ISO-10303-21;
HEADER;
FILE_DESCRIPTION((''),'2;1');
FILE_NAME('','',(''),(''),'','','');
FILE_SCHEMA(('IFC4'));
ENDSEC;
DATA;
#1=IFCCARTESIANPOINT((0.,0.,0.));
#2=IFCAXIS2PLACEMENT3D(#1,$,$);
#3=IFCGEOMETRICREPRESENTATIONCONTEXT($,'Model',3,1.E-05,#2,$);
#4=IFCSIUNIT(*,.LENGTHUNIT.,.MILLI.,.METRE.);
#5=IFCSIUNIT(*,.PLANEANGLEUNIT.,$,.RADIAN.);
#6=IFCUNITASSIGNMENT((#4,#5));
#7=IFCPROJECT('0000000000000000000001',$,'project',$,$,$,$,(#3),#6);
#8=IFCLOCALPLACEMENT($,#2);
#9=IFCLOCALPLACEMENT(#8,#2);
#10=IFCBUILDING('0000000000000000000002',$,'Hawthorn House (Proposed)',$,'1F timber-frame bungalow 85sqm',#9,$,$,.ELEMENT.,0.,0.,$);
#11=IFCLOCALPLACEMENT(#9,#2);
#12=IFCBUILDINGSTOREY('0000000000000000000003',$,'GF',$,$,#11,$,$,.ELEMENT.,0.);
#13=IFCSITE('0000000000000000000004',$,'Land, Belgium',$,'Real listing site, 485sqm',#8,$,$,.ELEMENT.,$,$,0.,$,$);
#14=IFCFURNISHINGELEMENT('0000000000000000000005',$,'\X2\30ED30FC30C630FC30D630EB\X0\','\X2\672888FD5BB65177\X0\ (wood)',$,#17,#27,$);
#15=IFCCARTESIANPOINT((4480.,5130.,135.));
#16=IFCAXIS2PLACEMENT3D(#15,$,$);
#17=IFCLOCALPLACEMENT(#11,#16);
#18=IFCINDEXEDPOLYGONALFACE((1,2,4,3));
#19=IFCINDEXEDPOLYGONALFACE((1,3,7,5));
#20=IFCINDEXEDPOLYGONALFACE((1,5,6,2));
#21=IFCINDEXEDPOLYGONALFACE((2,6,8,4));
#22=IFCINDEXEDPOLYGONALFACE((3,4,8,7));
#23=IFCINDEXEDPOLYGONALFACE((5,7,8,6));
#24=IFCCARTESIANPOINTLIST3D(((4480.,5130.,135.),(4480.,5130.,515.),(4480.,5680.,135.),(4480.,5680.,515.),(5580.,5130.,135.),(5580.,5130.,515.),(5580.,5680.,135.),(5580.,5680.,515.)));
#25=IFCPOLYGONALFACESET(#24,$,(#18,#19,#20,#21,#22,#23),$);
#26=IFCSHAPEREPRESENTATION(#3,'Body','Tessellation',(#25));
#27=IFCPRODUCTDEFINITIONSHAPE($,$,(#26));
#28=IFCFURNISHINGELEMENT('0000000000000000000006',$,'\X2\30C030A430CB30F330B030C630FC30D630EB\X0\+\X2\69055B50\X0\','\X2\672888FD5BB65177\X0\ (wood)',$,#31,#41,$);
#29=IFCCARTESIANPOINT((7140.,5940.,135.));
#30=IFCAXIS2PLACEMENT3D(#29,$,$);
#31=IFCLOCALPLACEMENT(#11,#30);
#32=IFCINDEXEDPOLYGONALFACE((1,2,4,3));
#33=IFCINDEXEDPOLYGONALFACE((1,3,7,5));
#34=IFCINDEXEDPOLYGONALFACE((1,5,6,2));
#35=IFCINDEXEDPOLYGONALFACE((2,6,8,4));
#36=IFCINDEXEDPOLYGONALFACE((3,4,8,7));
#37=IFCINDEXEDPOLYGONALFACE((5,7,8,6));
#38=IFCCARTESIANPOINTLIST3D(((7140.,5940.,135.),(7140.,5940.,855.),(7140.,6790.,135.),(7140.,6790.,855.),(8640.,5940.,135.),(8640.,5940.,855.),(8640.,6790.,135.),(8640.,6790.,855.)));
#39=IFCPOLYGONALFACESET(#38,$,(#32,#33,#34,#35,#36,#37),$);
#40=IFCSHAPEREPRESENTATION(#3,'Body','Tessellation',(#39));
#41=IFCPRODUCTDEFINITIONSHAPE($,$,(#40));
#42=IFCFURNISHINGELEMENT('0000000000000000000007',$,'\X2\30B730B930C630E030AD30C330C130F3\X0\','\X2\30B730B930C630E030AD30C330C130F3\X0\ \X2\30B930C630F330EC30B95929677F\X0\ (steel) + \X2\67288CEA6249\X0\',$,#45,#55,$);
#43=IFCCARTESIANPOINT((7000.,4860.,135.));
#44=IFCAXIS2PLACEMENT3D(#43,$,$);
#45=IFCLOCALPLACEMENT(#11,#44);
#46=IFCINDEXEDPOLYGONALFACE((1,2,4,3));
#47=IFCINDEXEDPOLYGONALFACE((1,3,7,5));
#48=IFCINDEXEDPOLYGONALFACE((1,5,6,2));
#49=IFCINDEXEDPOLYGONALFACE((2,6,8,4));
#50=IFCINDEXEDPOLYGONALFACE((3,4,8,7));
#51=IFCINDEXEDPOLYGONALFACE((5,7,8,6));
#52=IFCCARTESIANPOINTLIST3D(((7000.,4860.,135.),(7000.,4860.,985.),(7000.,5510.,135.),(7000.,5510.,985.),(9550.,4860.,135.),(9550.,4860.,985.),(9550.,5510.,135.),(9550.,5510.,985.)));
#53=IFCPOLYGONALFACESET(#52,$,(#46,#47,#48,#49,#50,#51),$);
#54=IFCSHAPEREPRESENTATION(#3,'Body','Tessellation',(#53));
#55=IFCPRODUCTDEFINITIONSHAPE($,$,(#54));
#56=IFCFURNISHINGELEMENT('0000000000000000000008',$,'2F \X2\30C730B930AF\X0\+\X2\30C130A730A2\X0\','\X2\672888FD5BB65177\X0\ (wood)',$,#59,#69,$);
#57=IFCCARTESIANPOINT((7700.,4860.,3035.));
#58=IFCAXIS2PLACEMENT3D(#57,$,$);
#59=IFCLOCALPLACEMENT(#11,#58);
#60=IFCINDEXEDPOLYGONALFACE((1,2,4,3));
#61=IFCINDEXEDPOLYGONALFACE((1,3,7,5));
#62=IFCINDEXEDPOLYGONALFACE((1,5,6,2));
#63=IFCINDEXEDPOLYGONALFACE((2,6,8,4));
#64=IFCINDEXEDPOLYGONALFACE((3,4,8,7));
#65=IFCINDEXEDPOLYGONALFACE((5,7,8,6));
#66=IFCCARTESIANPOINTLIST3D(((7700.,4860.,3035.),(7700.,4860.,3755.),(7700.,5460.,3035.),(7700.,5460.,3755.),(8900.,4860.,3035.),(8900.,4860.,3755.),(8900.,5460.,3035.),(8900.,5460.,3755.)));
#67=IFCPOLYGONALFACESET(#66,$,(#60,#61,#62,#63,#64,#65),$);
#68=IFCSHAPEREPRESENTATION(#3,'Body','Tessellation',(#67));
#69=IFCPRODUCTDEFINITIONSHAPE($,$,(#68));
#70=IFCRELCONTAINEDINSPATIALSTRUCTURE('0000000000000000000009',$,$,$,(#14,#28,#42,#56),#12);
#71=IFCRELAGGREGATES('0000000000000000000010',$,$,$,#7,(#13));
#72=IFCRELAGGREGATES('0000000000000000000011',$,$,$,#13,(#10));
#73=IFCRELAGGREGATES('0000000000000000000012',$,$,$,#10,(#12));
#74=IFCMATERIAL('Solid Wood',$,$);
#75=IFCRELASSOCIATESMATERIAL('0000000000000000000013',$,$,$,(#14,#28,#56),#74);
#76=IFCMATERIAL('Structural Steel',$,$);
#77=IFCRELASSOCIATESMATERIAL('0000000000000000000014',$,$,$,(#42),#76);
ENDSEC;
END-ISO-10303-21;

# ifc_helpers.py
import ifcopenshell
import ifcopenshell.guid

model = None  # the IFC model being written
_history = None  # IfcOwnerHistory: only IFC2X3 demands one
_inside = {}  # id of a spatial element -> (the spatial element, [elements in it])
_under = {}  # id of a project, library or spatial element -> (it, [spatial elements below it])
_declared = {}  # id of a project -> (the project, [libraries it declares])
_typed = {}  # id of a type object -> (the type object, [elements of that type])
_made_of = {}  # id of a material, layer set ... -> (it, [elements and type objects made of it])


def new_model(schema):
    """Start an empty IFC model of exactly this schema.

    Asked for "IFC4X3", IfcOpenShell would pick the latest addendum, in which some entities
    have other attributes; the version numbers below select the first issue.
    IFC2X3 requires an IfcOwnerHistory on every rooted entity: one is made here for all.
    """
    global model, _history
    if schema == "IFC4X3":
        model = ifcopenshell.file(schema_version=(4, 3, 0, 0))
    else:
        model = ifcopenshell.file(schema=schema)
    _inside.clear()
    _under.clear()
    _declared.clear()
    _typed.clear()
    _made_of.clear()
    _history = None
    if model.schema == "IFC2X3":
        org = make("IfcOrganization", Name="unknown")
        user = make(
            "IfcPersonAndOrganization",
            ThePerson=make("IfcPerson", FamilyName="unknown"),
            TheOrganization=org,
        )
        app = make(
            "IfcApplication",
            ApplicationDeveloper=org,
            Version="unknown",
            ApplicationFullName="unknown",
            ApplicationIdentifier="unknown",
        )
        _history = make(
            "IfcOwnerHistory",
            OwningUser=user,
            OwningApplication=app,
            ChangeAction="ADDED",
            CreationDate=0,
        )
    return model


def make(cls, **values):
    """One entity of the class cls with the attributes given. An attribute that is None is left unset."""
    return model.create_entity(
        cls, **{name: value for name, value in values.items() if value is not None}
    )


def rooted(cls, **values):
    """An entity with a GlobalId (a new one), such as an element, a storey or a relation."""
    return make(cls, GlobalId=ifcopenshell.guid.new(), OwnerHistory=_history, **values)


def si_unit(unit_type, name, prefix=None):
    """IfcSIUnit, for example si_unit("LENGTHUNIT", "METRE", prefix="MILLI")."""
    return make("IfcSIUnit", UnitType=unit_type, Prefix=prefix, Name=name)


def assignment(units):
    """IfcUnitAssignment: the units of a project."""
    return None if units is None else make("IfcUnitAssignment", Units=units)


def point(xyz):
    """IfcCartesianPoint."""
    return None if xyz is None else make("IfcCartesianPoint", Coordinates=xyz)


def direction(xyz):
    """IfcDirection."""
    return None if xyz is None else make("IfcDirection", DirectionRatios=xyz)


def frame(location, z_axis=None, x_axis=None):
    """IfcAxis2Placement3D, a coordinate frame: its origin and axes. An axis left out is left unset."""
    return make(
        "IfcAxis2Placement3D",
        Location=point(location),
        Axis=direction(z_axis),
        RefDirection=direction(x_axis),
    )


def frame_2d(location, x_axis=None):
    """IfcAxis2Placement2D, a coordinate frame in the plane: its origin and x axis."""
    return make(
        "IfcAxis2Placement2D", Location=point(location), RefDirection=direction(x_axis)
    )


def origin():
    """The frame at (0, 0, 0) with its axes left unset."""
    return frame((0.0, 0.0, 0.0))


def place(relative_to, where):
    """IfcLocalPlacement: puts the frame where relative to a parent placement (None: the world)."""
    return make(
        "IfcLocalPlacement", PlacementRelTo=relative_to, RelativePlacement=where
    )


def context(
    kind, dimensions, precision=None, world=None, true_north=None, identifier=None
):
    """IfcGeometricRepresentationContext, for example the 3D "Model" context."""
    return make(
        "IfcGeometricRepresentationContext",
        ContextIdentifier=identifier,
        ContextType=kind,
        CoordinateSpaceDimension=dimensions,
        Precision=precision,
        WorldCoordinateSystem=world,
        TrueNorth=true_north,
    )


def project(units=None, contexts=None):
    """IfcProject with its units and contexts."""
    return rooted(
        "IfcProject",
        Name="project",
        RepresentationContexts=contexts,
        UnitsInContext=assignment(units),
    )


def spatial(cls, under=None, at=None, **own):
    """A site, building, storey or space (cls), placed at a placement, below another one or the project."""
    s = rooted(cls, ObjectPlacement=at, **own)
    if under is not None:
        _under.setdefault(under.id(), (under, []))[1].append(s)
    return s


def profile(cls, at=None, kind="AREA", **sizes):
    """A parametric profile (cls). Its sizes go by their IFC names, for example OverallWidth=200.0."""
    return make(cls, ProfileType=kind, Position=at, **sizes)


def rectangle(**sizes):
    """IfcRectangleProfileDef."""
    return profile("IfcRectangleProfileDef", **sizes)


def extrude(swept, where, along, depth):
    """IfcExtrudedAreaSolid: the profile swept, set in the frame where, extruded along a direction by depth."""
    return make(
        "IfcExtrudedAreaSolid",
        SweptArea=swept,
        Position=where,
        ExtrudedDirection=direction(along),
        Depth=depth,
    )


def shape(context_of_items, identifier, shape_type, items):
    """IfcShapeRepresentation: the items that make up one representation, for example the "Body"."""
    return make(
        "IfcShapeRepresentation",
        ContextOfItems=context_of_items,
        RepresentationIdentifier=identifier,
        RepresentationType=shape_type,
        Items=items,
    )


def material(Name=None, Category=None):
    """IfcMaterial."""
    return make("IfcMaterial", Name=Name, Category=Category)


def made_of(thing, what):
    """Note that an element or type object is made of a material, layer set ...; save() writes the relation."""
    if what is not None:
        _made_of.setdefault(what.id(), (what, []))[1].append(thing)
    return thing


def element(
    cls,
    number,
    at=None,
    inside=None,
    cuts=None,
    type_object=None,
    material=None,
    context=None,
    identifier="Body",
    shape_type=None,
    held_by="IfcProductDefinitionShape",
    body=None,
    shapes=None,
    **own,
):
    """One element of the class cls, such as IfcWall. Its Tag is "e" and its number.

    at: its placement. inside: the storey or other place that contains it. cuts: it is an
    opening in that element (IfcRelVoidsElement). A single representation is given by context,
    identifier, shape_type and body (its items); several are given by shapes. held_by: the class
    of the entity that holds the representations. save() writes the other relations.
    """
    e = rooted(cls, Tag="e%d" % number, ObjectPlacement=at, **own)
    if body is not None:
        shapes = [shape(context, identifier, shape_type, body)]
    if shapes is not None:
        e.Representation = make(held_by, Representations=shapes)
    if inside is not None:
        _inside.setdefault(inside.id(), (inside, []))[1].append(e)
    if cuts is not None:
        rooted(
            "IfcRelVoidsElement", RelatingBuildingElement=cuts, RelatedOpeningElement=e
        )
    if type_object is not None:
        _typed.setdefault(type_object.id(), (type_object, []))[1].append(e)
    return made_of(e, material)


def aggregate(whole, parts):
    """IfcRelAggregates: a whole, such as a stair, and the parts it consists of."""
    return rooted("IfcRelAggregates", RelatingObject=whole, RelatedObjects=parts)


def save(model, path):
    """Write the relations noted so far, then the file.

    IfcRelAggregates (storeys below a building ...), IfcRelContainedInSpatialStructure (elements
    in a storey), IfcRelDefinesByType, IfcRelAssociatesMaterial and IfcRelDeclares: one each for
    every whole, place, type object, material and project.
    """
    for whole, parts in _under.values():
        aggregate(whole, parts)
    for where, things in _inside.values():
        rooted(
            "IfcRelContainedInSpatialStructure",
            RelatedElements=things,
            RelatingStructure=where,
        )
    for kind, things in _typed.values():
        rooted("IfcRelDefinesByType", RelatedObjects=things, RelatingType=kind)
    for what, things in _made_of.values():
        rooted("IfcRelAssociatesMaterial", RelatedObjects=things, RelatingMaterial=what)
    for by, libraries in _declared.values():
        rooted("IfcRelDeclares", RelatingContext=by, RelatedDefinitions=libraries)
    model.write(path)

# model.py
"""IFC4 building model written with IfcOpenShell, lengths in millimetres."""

from ifc_helpers import new_model, si_unit, frame, frame_2d, origin, place, context, project, spatial, rectangle, extrude, material, element, save


model = new_model("IFC4")

# Units and contexts
model_context = context("Model", 3, precision=1e-05, world=origin())
ifc_project = project(units=[si_unit("LENGTHUNIT", "METRE", prefix="MILLI"), si_unit("PLANEANGLEUNIT", "RADIAN")], contexts=[model_context])

# Site, building, storey
site_placement = place(None, origin())
site = spatial("IfcSite", under=ifc_project, at=site_placement, Name="Land, Belgium", ObjectType="Real listing site, 485sqm", CompositionType="ELEMENT", RefElevation=0.0)
building_placement = place(site_placement, origin())
building = spatial("IfcBuilding", under=site, at=building_placement, Name="Hawthorn House (Proposed)", ObjectType="1F timber-frame bungalow 85sqm", CompositionType="ELEMENT", ElevationOfRefHeight=0.0, ElevationOfTerrain=0.0)
storey_placement = place(building_placement, origin())
storey = spatial("IfcBuildingStorey", under=building, at=storey_placement, Name="GF", CompositionType="ELEMENT", Elevation=0.0)

# Shared definitions
ifc_material_1 = material(Name="Solid Wood")

# Shared definitions
ifc_material_2 = material(Name="Structural Steel")

# Furnishing elements
furnishing_1_placement = place(storey_placement, frame((4480.0, 5130.0, 135.0)))
element("IfcFurnishingElement", 1, at=furnishing_1_placement, inside=storey, material=ifc_material_1, Name="ローテーブル", Description="木製家具 (wood)", context=model_context, shape_type="SweptSolid", body=[
    extrude(rectangle(XDim=1100.0, YDim=550.0, at=frame_2d((550.0, 275.0))), frame((4480.0, 5130.0, 135.0)), (0.0, 0.0, 1.0), 380.0),
])
furnishing_2_placement = place(storey_placement, frame((7140.0, 5940.0, 135.0)))
element("IfcFurnishingElement", 2, at=furnishing_2_placement, inside=storey, material=ifc_material_1, Name="ダイニングテーブル+椅子", Description="木製家具 (wood)", context=model_context, shape_type="SweptSolid", body=[
    extrude(rectangle(XDim=1500.0, YDim=850.0, at=frame_2d((750.0, 425.0))), frame((7140.0, 5940.0, 135.0)), (0.0, 0.0, 1.0), 720.0),
])
furnishing_3_placement = place(storey_placement, frame((7000.0, 4860.0, 135.0)))
element("IfcFurnishingElement", 3, at=furnishing_3_placement, inside=storey, material=ifc_material_2, Name="システムキッチン", Description="システムキッチン ステンレス天板 (steel) + 木質扉", context=model_context, shape_type="SweptSolid", body=[
    extrude(rectangle(XDim=2550.0, YDim=650.0, at=frame_2d((1275.0, 325.0))), frame((7000.0, 4860.0, 135.0)), (0.0, 0.0, 1.0), 850.0),
])
furnishing_4_placement = place(storey_placement, frame((7700.0, 4860.0, 3035.0)))
element("IfcFurnishingElement", 4, at=furnishing_4_placement, inside=storey, material=ifc_material_1, Name="2F デスク+チェア", Description="木製家具 (wood)", context=model_context, shape_type="SweptSolid", body=[
    extrude(rectangle(XDim=1200.0, YDim=600.0, at=frame_2d((600.0, 300.0))), frame((7700.0, 4860.0, 3035.0)), (0.0, 0.0, 1.0), 720.0),
])

save(model, "model.ifc")
